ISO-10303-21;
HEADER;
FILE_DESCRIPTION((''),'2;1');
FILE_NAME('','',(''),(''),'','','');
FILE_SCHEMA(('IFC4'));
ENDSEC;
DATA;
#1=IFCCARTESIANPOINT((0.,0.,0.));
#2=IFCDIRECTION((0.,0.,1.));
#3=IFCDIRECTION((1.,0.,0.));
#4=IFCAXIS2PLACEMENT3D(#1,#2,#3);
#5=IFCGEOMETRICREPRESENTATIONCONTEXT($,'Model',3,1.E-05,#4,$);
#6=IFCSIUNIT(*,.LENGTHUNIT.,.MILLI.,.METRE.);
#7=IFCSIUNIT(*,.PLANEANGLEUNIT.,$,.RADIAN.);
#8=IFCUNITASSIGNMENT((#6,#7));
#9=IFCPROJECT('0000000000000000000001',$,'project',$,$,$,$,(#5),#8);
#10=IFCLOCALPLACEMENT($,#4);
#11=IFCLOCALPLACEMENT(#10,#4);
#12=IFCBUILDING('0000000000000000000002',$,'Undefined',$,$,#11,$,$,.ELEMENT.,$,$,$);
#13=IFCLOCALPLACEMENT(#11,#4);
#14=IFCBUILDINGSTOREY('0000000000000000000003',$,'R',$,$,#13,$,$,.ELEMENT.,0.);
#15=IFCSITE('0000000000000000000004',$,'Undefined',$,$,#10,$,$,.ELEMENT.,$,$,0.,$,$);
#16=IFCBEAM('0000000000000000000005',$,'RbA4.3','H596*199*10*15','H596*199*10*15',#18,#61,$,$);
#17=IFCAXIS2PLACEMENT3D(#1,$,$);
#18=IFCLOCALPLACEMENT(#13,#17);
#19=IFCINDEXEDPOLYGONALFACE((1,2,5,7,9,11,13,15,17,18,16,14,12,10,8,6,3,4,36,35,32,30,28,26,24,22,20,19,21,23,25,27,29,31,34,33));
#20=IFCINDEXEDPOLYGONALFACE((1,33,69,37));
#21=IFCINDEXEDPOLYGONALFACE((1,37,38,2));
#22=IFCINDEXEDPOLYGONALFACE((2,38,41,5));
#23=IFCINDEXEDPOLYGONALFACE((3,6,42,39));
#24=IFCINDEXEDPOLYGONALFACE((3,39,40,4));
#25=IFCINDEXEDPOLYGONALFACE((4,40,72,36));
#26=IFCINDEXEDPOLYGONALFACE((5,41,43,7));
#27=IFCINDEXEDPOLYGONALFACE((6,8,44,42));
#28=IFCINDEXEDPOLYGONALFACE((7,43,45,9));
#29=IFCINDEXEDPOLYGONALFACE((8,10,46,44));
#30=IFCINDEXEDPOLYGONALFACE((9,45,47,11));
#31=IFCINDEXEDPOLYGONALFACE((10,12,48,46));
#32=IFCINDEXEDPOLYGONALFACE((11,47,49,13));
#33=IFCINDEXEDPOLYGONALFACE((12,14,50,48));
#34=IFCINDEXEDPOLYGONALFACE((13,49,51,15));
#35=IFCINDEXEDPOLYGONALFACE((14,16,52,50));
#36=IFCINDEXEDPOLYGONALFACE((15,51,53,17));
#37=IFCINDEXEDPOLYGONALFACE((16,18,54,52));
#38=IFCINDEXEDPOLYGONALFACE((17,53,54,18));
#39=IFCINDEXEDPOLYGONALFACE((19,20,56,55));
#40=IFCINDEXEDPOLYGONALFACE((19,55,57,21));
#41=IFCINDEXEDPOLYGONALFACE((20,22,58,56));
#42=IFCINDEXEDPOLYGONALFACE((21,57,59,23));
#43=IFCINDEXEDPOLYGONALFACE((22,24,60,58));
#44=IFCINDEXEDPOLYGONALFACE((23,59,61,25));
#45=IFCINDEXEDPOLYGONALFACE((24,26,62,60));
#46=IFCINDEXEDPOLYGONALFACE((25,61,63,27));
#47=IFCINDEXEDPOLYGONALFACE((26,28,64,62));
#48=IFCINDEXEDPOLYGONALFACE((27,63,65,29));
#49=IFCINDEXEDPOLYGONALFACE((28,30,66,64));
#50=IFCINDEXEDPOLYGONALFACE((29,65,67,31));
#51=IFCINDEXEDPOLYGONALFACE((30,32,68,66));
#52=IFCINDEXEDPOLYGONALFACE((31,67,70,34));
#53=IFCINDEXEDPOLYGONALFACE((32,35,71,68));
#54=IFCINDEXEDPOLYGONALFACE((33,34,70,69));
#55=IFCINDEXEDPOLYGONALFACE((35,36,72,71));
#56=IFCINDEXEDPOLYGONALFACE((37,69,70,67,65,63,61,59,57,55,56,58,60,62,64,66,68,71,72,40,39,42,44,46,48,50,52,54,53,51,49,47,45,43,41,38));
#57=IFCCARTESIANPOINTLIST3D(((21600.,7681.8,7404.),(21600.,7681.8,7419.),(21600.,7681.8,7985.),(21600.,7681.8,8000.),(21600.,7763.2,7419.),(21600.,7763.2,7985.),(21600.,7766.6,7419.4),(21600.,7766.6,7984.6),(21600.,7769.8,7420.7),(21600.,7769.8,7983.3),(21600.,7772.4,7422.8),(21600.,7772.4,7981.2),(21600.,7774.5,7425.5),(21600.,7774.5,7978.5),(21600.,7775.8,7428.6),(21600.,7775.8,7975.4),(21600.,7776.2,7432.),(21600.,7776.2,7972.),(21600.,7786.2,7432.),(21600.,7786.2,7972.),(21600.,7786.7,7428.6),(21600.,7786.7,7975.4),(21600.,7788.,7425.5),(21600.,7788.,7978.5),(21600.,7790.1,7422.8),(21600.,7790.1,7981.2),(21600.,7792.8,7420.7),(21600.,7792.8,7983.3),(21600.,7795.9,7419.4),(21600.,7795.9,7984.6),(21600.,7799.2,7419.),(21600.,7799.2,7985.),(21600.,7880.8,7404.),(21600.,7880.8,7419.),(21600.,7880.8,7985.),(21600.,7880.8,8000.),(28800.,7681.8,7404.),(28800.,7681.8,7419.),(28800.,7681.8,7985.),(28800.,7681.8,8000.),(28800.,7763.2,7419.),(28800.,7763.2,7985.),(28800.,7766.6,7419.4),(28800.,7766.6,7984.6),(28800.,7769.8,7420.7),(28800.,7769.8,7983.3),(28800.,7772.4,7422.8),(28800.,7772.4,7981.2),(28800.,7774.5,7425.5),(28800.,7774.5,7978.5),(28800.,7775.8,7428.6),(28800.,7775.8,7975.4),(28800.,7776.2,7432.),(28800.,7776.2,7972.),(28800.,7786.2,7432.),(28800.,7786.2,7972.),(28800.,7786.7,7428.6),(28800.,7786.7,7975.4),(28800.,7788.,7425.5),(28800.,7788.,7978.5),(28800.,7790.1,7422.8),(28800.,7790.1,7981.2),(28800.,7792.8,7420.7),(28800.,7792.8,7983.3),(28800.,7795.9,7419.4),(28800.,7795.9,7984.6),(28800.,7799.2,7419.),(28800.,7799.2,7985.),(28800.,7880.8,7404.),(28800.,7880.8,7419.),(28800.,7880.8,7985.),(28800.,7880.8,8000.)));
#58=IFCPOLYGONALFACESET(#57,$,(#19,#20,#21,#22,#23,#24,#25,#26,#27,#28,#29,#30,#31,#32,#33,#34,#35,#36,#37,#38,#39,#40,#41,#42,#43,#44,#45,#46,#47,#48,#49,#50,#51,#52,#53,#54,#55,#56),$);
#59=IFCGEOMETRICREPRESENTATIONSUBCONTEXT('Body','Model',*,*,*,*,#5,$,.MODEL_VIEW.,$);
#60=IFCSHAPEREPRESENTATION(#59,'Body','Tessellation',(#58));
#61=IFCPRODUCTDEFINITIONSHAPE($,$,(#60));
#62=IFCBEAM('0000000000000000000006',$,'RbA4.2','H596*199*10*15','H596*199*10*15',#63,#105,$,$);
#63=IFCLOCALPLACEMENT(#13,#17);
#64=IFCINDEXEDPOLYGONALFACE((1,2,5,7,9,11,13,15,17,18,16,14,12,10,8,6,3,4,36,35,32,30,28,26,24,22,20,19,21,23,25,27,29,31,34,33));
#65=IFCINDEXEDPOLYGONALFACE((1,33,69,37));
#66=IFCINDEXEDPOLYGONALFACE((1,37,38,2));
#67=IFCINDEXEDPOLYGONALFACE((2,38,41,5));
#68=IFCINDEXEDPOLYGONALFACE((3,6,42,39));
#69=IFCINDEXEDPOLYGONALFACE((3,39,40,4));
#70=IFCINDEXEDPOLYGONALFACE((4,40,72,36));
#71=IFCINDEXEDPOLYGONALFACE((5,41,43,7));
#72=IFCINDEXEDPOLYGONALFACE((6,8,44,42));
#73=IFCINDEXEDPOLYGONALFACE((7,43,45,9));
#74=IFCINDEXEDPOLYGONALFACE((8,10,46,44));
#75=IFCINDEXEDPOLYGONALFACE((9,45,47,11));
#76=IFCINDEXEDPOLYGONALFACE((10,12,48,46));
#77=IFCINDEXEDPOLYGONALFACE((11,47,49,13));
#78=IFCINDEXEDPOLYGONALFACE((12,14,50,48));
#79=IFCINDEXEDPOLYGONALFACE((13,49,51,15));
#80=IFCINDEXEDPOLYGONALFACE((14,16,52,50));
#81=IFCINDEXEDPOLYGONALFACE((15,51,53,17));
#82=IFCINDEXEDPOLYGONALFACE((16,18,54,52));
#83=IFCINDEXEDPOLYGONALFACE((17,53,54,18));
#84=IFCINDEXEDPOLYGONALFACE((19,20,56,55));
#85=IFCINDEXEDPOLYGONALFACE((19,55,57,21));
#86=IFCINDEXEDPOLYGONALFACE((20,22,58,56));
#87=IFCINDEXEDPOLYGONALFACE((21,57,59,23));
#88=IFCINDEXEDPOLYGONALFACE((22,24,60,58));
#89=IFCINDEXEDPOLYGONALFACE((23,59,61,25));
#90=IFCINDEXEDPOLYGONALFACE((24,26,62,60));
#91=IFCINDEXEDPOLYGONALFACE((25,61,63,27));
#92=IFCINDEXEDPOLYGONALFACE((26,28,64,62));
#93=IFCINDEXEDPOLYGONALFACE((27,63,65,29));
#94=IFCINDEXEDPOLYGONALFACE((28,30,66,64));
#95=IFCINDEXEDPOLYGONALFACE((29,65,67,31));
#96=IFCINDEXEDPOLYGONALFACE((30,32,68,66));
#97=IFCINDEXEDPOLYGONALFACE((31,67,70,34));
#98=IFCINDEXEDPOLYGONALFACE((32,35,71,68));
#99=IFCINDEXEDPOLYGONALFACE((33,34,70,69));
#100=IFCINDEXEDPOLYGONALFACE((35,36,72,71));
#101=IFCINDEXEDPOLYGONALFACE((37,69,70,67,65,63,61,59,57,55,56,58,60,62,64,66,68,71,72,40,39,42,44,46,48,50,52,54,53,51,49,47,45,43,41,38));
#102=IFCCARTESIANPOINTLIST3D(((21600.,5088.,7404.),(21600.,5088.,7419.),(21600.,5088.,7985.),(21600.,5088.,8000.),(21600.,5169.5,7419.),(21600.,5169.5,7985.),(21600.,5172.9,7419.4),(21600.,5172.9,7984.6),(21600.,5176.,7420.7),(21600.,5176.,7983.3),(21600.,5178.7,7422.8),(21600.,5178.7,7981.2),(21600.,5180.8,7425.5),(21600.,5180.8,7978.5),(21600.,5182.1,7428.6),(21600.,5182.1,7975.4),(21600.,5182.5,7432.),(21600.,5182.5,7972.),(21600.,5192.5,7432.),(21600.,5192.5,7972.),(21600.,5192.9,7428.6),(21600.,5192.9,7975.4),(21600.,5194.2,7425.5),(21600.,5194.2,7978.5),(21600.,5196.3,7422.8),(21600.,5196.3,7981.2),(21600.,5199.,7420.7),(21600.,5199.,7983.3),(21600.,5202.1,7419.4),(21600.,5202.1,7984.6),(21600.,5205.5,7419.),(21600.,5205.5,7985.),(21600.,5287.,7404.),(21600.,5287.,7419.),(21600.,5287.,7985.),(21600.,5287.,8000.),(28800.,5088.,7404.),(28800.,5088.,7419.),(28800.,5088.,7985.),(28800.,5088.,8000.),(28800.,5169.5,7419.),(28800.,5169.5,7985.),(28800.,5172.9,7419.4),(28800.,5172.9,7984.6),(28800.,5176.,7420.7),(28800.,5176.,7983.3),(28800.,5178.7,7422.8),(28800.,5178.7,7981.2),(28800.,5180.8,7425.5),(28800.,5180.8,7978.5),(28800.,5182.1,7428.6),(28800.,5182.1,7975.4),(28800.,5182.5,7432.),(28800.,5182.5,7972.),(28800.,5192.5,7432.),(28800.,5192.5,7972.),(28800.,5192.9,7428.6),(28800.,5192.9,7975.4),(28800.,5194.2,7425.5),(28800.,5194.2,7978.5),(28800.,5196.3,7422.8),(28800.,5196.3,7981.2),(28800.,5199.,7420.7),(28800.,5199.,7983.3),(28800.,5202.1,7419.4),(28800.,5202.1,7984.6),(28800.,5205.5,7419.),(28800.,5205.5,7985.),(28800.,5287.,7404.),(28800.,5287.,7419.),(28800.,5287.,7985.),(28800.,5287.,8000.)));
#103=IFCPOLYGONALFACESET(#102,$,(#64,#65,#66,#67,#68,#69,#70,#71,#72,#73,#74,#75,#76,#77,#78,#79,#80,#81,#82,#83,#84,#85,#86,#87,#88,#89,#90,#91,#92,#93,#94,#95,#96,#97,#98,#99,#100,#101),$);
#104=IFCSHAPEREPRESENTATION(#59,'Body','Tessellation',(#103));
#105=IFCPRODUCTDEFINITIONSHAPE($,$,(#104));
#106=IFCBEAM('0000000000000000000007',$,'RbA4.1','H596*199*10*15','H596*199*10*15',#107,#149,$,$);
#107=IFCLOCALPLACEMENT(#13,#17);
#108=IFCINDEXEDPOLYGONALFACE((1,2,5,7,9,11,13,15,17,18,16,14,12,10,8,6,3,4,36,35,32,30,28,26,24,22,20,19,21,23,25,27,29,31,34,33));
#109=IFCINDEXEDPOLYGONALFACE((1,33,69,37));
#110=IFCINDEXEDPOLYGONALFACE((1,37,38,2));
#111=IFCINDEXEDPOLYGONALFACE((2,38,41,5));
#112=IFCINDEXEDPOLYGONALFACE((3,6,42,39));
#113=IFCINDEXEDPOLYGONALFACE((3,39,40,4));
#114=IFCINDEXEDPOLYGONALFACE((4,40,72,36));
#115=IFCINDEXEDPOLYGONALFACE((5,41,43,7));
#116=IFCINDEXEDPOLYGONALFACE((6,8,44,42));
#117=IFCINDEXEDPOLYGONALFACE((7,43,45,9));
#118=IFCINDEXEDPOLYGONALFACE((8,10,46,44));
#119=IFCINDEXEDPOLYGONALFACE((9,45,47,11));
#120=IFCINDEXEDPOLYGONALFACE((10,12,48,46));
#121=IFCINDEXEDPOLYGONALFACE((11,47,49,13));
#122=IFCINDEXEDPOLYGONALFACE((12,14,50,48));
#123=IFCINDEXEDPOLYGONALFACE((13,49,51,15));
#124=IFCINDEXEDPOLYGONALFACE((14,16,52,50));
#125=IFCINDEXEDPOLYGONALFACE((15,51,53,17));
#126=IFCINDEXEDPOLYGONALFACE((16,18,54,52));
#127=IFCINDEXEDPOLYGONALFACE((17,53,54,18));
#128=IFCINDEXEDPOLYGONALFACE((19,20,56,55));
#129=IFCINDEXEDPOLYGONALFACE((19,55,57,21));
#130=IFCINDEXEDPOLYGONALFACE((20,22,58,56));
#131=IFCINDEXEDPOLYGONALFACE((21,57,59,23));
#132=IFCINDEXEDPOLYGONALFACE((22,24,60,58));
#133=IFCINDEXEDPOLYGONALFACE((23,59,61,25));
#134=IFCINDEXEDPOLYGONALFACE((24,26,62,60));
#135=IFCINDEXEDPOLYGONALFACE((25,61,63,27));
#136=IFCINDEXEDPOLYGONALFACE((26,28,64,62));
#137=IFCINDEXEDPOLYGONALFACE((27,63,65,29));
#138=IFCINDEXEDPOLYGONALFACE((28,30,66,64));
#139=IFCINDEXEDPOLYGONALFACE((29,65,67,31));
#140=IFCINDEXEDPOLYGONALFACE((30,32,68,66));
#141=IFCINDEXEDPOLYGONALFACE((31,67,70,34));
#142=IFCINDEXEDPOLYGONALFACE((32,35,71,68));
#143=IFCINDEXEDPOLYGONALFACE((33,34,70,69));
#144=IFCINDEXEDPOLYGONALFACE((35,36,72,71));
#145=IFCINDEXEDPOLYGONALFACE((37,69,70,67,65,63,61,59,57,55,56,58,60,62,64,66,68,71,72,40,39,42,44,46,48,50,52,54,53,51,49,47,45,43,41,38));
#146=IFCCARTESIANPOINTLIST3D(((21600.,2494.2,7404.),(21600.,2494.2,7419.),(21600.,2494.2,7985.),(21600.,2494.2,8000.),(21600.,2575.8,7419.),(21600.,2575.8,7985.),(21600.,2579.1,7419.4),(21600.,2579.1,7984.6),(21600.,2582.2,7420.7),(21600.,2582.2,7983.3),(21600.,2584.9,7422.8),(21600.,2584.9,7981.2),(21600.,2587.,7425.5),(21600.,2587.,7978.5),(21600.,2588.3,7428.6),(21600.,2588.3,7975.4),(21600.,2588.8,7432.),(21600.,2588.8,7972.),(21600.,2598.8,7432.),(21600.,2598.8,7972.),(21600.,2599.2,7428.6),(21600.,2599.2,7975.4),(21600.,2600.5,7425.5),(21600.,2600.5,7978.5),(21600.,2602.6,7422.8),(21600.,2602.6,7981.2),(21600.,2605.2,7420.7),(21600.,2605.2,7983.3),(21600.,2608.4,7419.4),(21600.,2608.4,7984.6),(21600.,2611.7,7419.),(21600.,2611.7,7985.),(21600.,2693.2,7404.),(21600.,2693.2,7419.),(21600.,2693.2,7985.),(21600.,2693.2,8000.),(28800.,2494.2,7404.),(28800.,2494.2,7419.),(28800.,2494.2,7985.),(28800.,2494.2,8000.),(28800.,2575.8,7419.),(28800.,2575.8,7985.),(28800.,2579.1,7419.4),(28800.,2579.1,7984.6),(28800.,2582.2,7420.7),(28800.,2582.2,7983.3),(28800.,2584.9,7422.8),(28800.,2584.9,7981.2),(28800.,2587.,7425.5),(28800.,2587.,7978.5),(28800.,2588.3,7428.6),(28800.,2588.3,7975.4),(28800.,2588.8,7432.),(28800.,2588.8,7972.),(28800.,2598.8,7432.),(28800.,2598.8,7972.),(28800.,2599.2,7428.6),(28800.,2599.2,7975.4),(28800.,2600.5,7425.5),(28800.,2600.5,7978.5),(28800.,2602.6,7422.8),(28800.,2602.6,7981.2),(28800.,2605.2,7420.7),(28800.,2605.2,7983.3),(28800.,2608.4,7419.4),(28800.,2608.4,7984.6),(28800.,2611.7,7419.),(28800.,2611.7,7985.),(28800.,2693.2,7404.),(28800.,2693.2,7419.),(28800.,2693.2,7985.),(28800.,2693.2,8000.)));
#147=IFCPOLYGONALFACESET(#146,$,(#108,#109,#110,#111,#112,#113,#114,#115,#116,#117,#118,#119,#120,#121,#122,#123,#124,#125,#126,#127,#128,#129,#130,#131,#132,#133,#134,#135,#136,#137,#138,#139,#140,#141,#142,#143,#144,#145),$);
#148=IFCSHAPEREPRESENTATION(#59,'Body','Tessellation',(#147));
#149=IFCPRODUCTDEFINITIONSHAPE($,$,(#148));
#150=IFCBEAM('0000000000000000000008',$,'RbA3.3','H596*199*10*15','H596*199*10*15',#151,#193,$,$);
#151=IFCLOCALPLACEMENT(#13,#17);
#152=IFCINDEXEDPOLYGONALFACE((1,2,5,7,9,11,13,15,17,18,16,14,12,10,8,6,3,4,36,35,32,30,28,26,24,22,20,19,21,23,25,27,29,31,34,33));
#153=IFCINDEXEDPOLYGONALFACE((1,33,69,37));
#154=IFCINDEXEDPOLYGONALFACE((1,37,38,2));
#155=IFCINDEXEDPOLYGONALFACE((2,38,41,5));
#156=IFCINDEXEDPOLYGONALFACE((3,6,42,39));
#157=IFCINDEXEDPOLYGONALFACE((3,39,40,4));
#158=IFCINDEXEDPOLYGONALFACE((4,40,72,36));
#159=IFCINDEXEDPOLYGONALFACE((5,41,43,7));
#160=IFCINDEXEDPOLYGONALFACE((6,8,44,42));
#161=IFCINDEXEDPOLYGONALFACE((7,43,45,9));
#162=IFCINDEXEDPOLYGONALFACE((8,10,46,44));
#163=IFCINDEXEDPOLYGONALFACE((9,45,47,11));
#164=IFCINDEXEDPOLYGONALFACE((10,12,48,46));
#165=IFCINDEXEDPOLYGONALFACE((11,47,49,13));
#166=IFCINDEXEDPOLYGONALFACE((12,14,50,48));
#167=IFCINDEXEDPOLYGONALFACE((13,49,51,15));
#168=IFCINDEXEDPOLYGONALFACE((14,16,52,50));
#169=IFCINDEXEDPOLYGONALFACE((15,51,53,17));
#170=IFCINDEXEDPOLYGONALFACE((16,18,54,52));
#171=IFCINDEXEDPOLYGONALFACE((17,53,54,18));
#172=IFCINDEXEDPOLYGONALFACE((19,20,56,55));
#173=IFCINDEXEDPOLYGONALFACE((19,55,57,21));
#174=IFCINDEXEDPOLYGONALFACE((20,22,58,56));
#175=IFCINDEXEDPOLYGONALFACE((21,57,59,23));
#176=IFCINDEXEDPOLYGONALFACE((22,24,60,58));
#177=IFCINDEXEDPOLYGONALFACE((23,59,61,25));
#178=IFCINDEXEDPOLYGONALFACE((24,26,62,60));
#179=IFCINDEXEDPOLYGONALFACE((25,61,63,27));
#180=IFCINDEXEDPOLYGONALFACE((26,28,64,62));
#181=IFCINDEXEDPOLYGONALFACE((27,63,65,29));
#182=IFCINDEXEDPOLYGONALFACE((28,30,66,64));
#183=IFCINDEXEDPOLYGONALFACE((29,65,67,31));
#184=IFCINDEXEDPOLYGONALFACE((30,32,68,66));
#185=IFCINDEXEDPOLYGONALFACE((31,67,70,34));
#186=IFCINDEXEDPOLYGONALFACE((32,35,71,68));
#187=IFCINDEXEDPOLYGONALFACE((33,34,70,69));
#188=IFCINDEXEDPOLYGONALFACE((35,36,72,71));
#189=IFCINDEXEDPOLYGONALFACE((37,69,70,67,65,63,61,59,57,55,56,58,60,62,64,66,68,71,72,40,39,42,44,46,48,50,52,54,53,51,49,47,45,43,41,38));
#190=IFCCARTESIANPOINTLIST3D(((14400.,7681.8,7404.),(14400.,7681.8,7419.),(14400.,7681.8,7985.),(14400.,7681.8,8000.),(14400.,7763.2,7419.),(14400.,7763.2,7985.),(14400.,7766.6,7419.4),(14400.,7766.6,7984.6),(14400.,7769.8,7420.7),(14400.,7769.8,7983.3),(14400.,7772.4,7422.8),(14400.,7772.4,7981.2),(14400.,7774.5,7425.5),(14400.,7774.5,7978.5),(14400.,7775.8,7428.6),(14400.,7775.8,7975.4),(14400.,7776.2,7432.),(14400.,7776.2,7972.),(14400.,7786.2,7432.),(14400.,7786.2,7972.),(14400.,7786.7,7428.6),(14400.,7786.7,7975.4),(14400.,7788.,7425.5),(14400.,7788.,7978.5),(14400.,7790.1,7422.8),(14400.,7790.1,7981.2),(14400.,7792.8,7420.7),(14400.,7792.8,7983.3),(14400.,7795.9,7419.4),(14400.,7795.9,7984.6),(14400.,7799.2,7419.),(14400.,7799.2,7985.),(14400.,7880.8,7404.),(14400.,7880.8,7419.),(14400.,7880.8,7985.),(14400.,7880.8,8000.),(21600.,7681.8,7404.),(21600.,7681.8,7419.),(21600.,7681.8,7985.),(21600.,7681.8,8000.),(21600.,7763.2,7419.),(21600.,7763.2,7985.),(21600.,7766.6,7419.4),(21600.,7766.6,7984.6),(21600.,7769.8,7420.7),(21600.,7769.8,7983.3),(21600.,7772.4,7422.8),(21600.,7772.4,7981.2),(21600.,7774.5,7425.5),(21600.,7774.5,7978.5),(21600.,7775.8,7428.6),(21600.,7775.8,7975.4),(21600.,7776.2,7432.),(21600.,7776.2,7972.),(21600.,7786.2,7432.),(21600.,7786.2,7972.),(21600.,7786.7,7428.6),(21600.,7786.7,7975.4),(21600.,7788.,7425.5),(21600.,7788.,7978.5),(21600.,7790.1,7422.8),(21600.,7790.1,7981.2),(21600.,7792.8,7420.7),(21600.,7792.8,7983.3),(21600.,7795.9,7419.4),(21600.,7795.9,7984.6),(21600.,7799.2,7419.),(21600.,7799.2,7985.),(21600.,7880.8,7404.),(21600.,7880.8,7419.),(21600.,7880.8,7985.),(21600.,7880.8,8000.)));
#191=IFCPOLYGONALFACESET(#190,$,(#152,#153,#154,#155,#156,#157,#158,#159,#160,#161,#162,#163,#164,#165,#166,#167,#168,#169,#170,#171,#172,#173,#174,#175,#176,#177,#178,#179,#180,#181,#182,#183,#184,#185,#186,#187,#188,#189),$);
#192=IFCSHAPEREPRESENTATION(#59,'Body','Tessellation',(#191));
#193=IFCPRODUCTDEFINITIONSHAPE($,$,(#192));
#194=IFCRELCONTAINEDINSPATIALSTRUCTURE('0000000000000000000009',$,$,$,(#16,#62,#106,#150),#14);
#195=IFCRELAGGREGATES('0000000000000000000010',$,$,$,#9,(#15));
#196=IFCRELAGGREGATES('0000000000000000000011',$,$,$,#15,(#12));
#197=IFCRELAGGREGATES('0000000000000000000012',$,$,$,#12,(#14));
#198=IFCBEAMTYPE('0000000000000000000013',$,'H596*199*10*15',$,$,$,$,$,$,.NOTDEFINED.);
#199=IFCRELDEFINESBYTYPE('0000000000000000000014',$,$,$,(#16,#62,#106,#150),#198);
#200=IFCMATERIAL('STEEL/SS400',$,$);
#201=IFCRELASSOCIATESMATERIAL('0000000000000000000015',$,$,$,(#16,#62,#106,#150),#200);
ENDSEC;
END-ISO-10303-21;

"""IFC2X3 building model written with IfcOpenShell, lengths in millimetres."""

from ifc_helpers import new_model, si_unit, frame, origin_with_axes, origin_2d_with_axis, place, context, subcontext, project, spatial, i_section, extrude, material, type_object, element, save


model = new_model("IFC2X3")

# Units and contexts
model_context = context("Model", 3, precision=1e-05, world=origin_with_axes())
body_context = subcontext(model_context, "Body", "Model", "MODEL_VIEW")
ifc_project = project(units=[si_unit("LENGTHUNIT", "METRE", prefix="MILLI"), si_unit("PLANEANGLEUNIT", "RADIAN")], contexts=[model_context])

# Site, building, storey
site_placement = place(None, origin_with_axes())
site = spatial("IfcSite", under=ifc_project, at=site_placement, Name="Undefined", CompositionType="ELEMENT", RefElevation=0.0)
building_placement = place(site_placement, origin_with_axes())
building = spatial("IfcBuilding", under=site, at=building_placement, Name="Undefined", CompositionType="ELEMENT")
storey_placement = place(building_placement, origin_with_axes())
storey = spatial("IfcBuildingStorey", under=building, at=storey_placement, Name="R", CompositionType="ELEMENT", Elevation=0.0)

# Beams
ifc_material_1 = material(Name="STEEL/SS400")
beam_type_1 = type_object("IfcBeamType", Name="H596*199*10*15", PredefinedType="NOTDEFINED")
for number, where, z_axis, x_axis, name in (
    (1, (21600.0, 7781.2, 7702.0), (0.0, 0.0, 1.0), (1.0, 0.0, 0.0), "RbA4.3"),
    (2, (21600.0, 5187.5, 7702.0), (0.0, 0.0, 1.0), (1.0, 0.0, 0.0), "RbA4.2"),
    (3, (21600.0, 2593.8, 7702.0), (0.0, 0.0, 1.0), (1.0, 0.0, 0.0), "RbA4.1"),
    (4, (14400.0, 7781.2, 7702.0), (0.0, 0.0, 1.0), (1.0, 0.0, 0.0), "RbA3.3"),
):
    element("IfcBeam", number, at=place(storey_placement, frame(where, z_axis=z_axis, x_axis=x_axis)), inside=storey, type_object=beam_type_1, material=ifc_material_1, Name=name, Description="H596*199*10*15", ObjectType="H596*199*10*15", context=body_context, shape_type="SweptSolid", body=[
        extrude(i_section(OverallWidth=199.0, OverallDepth=596.0, WebThickness=10.0, FlangeThickness=15.0, FilletRadius=13.0, at=origin_2d_with_axis()), frame((7200.0, 0.0, 0.0), z_axis=(-1.0, 0.0, 0.0), x_axis=(0.0, -1.0, 0.0)), (0.0, 0.0, 1.0), 7200.0),
    ])

save(model, "model.ifc")
